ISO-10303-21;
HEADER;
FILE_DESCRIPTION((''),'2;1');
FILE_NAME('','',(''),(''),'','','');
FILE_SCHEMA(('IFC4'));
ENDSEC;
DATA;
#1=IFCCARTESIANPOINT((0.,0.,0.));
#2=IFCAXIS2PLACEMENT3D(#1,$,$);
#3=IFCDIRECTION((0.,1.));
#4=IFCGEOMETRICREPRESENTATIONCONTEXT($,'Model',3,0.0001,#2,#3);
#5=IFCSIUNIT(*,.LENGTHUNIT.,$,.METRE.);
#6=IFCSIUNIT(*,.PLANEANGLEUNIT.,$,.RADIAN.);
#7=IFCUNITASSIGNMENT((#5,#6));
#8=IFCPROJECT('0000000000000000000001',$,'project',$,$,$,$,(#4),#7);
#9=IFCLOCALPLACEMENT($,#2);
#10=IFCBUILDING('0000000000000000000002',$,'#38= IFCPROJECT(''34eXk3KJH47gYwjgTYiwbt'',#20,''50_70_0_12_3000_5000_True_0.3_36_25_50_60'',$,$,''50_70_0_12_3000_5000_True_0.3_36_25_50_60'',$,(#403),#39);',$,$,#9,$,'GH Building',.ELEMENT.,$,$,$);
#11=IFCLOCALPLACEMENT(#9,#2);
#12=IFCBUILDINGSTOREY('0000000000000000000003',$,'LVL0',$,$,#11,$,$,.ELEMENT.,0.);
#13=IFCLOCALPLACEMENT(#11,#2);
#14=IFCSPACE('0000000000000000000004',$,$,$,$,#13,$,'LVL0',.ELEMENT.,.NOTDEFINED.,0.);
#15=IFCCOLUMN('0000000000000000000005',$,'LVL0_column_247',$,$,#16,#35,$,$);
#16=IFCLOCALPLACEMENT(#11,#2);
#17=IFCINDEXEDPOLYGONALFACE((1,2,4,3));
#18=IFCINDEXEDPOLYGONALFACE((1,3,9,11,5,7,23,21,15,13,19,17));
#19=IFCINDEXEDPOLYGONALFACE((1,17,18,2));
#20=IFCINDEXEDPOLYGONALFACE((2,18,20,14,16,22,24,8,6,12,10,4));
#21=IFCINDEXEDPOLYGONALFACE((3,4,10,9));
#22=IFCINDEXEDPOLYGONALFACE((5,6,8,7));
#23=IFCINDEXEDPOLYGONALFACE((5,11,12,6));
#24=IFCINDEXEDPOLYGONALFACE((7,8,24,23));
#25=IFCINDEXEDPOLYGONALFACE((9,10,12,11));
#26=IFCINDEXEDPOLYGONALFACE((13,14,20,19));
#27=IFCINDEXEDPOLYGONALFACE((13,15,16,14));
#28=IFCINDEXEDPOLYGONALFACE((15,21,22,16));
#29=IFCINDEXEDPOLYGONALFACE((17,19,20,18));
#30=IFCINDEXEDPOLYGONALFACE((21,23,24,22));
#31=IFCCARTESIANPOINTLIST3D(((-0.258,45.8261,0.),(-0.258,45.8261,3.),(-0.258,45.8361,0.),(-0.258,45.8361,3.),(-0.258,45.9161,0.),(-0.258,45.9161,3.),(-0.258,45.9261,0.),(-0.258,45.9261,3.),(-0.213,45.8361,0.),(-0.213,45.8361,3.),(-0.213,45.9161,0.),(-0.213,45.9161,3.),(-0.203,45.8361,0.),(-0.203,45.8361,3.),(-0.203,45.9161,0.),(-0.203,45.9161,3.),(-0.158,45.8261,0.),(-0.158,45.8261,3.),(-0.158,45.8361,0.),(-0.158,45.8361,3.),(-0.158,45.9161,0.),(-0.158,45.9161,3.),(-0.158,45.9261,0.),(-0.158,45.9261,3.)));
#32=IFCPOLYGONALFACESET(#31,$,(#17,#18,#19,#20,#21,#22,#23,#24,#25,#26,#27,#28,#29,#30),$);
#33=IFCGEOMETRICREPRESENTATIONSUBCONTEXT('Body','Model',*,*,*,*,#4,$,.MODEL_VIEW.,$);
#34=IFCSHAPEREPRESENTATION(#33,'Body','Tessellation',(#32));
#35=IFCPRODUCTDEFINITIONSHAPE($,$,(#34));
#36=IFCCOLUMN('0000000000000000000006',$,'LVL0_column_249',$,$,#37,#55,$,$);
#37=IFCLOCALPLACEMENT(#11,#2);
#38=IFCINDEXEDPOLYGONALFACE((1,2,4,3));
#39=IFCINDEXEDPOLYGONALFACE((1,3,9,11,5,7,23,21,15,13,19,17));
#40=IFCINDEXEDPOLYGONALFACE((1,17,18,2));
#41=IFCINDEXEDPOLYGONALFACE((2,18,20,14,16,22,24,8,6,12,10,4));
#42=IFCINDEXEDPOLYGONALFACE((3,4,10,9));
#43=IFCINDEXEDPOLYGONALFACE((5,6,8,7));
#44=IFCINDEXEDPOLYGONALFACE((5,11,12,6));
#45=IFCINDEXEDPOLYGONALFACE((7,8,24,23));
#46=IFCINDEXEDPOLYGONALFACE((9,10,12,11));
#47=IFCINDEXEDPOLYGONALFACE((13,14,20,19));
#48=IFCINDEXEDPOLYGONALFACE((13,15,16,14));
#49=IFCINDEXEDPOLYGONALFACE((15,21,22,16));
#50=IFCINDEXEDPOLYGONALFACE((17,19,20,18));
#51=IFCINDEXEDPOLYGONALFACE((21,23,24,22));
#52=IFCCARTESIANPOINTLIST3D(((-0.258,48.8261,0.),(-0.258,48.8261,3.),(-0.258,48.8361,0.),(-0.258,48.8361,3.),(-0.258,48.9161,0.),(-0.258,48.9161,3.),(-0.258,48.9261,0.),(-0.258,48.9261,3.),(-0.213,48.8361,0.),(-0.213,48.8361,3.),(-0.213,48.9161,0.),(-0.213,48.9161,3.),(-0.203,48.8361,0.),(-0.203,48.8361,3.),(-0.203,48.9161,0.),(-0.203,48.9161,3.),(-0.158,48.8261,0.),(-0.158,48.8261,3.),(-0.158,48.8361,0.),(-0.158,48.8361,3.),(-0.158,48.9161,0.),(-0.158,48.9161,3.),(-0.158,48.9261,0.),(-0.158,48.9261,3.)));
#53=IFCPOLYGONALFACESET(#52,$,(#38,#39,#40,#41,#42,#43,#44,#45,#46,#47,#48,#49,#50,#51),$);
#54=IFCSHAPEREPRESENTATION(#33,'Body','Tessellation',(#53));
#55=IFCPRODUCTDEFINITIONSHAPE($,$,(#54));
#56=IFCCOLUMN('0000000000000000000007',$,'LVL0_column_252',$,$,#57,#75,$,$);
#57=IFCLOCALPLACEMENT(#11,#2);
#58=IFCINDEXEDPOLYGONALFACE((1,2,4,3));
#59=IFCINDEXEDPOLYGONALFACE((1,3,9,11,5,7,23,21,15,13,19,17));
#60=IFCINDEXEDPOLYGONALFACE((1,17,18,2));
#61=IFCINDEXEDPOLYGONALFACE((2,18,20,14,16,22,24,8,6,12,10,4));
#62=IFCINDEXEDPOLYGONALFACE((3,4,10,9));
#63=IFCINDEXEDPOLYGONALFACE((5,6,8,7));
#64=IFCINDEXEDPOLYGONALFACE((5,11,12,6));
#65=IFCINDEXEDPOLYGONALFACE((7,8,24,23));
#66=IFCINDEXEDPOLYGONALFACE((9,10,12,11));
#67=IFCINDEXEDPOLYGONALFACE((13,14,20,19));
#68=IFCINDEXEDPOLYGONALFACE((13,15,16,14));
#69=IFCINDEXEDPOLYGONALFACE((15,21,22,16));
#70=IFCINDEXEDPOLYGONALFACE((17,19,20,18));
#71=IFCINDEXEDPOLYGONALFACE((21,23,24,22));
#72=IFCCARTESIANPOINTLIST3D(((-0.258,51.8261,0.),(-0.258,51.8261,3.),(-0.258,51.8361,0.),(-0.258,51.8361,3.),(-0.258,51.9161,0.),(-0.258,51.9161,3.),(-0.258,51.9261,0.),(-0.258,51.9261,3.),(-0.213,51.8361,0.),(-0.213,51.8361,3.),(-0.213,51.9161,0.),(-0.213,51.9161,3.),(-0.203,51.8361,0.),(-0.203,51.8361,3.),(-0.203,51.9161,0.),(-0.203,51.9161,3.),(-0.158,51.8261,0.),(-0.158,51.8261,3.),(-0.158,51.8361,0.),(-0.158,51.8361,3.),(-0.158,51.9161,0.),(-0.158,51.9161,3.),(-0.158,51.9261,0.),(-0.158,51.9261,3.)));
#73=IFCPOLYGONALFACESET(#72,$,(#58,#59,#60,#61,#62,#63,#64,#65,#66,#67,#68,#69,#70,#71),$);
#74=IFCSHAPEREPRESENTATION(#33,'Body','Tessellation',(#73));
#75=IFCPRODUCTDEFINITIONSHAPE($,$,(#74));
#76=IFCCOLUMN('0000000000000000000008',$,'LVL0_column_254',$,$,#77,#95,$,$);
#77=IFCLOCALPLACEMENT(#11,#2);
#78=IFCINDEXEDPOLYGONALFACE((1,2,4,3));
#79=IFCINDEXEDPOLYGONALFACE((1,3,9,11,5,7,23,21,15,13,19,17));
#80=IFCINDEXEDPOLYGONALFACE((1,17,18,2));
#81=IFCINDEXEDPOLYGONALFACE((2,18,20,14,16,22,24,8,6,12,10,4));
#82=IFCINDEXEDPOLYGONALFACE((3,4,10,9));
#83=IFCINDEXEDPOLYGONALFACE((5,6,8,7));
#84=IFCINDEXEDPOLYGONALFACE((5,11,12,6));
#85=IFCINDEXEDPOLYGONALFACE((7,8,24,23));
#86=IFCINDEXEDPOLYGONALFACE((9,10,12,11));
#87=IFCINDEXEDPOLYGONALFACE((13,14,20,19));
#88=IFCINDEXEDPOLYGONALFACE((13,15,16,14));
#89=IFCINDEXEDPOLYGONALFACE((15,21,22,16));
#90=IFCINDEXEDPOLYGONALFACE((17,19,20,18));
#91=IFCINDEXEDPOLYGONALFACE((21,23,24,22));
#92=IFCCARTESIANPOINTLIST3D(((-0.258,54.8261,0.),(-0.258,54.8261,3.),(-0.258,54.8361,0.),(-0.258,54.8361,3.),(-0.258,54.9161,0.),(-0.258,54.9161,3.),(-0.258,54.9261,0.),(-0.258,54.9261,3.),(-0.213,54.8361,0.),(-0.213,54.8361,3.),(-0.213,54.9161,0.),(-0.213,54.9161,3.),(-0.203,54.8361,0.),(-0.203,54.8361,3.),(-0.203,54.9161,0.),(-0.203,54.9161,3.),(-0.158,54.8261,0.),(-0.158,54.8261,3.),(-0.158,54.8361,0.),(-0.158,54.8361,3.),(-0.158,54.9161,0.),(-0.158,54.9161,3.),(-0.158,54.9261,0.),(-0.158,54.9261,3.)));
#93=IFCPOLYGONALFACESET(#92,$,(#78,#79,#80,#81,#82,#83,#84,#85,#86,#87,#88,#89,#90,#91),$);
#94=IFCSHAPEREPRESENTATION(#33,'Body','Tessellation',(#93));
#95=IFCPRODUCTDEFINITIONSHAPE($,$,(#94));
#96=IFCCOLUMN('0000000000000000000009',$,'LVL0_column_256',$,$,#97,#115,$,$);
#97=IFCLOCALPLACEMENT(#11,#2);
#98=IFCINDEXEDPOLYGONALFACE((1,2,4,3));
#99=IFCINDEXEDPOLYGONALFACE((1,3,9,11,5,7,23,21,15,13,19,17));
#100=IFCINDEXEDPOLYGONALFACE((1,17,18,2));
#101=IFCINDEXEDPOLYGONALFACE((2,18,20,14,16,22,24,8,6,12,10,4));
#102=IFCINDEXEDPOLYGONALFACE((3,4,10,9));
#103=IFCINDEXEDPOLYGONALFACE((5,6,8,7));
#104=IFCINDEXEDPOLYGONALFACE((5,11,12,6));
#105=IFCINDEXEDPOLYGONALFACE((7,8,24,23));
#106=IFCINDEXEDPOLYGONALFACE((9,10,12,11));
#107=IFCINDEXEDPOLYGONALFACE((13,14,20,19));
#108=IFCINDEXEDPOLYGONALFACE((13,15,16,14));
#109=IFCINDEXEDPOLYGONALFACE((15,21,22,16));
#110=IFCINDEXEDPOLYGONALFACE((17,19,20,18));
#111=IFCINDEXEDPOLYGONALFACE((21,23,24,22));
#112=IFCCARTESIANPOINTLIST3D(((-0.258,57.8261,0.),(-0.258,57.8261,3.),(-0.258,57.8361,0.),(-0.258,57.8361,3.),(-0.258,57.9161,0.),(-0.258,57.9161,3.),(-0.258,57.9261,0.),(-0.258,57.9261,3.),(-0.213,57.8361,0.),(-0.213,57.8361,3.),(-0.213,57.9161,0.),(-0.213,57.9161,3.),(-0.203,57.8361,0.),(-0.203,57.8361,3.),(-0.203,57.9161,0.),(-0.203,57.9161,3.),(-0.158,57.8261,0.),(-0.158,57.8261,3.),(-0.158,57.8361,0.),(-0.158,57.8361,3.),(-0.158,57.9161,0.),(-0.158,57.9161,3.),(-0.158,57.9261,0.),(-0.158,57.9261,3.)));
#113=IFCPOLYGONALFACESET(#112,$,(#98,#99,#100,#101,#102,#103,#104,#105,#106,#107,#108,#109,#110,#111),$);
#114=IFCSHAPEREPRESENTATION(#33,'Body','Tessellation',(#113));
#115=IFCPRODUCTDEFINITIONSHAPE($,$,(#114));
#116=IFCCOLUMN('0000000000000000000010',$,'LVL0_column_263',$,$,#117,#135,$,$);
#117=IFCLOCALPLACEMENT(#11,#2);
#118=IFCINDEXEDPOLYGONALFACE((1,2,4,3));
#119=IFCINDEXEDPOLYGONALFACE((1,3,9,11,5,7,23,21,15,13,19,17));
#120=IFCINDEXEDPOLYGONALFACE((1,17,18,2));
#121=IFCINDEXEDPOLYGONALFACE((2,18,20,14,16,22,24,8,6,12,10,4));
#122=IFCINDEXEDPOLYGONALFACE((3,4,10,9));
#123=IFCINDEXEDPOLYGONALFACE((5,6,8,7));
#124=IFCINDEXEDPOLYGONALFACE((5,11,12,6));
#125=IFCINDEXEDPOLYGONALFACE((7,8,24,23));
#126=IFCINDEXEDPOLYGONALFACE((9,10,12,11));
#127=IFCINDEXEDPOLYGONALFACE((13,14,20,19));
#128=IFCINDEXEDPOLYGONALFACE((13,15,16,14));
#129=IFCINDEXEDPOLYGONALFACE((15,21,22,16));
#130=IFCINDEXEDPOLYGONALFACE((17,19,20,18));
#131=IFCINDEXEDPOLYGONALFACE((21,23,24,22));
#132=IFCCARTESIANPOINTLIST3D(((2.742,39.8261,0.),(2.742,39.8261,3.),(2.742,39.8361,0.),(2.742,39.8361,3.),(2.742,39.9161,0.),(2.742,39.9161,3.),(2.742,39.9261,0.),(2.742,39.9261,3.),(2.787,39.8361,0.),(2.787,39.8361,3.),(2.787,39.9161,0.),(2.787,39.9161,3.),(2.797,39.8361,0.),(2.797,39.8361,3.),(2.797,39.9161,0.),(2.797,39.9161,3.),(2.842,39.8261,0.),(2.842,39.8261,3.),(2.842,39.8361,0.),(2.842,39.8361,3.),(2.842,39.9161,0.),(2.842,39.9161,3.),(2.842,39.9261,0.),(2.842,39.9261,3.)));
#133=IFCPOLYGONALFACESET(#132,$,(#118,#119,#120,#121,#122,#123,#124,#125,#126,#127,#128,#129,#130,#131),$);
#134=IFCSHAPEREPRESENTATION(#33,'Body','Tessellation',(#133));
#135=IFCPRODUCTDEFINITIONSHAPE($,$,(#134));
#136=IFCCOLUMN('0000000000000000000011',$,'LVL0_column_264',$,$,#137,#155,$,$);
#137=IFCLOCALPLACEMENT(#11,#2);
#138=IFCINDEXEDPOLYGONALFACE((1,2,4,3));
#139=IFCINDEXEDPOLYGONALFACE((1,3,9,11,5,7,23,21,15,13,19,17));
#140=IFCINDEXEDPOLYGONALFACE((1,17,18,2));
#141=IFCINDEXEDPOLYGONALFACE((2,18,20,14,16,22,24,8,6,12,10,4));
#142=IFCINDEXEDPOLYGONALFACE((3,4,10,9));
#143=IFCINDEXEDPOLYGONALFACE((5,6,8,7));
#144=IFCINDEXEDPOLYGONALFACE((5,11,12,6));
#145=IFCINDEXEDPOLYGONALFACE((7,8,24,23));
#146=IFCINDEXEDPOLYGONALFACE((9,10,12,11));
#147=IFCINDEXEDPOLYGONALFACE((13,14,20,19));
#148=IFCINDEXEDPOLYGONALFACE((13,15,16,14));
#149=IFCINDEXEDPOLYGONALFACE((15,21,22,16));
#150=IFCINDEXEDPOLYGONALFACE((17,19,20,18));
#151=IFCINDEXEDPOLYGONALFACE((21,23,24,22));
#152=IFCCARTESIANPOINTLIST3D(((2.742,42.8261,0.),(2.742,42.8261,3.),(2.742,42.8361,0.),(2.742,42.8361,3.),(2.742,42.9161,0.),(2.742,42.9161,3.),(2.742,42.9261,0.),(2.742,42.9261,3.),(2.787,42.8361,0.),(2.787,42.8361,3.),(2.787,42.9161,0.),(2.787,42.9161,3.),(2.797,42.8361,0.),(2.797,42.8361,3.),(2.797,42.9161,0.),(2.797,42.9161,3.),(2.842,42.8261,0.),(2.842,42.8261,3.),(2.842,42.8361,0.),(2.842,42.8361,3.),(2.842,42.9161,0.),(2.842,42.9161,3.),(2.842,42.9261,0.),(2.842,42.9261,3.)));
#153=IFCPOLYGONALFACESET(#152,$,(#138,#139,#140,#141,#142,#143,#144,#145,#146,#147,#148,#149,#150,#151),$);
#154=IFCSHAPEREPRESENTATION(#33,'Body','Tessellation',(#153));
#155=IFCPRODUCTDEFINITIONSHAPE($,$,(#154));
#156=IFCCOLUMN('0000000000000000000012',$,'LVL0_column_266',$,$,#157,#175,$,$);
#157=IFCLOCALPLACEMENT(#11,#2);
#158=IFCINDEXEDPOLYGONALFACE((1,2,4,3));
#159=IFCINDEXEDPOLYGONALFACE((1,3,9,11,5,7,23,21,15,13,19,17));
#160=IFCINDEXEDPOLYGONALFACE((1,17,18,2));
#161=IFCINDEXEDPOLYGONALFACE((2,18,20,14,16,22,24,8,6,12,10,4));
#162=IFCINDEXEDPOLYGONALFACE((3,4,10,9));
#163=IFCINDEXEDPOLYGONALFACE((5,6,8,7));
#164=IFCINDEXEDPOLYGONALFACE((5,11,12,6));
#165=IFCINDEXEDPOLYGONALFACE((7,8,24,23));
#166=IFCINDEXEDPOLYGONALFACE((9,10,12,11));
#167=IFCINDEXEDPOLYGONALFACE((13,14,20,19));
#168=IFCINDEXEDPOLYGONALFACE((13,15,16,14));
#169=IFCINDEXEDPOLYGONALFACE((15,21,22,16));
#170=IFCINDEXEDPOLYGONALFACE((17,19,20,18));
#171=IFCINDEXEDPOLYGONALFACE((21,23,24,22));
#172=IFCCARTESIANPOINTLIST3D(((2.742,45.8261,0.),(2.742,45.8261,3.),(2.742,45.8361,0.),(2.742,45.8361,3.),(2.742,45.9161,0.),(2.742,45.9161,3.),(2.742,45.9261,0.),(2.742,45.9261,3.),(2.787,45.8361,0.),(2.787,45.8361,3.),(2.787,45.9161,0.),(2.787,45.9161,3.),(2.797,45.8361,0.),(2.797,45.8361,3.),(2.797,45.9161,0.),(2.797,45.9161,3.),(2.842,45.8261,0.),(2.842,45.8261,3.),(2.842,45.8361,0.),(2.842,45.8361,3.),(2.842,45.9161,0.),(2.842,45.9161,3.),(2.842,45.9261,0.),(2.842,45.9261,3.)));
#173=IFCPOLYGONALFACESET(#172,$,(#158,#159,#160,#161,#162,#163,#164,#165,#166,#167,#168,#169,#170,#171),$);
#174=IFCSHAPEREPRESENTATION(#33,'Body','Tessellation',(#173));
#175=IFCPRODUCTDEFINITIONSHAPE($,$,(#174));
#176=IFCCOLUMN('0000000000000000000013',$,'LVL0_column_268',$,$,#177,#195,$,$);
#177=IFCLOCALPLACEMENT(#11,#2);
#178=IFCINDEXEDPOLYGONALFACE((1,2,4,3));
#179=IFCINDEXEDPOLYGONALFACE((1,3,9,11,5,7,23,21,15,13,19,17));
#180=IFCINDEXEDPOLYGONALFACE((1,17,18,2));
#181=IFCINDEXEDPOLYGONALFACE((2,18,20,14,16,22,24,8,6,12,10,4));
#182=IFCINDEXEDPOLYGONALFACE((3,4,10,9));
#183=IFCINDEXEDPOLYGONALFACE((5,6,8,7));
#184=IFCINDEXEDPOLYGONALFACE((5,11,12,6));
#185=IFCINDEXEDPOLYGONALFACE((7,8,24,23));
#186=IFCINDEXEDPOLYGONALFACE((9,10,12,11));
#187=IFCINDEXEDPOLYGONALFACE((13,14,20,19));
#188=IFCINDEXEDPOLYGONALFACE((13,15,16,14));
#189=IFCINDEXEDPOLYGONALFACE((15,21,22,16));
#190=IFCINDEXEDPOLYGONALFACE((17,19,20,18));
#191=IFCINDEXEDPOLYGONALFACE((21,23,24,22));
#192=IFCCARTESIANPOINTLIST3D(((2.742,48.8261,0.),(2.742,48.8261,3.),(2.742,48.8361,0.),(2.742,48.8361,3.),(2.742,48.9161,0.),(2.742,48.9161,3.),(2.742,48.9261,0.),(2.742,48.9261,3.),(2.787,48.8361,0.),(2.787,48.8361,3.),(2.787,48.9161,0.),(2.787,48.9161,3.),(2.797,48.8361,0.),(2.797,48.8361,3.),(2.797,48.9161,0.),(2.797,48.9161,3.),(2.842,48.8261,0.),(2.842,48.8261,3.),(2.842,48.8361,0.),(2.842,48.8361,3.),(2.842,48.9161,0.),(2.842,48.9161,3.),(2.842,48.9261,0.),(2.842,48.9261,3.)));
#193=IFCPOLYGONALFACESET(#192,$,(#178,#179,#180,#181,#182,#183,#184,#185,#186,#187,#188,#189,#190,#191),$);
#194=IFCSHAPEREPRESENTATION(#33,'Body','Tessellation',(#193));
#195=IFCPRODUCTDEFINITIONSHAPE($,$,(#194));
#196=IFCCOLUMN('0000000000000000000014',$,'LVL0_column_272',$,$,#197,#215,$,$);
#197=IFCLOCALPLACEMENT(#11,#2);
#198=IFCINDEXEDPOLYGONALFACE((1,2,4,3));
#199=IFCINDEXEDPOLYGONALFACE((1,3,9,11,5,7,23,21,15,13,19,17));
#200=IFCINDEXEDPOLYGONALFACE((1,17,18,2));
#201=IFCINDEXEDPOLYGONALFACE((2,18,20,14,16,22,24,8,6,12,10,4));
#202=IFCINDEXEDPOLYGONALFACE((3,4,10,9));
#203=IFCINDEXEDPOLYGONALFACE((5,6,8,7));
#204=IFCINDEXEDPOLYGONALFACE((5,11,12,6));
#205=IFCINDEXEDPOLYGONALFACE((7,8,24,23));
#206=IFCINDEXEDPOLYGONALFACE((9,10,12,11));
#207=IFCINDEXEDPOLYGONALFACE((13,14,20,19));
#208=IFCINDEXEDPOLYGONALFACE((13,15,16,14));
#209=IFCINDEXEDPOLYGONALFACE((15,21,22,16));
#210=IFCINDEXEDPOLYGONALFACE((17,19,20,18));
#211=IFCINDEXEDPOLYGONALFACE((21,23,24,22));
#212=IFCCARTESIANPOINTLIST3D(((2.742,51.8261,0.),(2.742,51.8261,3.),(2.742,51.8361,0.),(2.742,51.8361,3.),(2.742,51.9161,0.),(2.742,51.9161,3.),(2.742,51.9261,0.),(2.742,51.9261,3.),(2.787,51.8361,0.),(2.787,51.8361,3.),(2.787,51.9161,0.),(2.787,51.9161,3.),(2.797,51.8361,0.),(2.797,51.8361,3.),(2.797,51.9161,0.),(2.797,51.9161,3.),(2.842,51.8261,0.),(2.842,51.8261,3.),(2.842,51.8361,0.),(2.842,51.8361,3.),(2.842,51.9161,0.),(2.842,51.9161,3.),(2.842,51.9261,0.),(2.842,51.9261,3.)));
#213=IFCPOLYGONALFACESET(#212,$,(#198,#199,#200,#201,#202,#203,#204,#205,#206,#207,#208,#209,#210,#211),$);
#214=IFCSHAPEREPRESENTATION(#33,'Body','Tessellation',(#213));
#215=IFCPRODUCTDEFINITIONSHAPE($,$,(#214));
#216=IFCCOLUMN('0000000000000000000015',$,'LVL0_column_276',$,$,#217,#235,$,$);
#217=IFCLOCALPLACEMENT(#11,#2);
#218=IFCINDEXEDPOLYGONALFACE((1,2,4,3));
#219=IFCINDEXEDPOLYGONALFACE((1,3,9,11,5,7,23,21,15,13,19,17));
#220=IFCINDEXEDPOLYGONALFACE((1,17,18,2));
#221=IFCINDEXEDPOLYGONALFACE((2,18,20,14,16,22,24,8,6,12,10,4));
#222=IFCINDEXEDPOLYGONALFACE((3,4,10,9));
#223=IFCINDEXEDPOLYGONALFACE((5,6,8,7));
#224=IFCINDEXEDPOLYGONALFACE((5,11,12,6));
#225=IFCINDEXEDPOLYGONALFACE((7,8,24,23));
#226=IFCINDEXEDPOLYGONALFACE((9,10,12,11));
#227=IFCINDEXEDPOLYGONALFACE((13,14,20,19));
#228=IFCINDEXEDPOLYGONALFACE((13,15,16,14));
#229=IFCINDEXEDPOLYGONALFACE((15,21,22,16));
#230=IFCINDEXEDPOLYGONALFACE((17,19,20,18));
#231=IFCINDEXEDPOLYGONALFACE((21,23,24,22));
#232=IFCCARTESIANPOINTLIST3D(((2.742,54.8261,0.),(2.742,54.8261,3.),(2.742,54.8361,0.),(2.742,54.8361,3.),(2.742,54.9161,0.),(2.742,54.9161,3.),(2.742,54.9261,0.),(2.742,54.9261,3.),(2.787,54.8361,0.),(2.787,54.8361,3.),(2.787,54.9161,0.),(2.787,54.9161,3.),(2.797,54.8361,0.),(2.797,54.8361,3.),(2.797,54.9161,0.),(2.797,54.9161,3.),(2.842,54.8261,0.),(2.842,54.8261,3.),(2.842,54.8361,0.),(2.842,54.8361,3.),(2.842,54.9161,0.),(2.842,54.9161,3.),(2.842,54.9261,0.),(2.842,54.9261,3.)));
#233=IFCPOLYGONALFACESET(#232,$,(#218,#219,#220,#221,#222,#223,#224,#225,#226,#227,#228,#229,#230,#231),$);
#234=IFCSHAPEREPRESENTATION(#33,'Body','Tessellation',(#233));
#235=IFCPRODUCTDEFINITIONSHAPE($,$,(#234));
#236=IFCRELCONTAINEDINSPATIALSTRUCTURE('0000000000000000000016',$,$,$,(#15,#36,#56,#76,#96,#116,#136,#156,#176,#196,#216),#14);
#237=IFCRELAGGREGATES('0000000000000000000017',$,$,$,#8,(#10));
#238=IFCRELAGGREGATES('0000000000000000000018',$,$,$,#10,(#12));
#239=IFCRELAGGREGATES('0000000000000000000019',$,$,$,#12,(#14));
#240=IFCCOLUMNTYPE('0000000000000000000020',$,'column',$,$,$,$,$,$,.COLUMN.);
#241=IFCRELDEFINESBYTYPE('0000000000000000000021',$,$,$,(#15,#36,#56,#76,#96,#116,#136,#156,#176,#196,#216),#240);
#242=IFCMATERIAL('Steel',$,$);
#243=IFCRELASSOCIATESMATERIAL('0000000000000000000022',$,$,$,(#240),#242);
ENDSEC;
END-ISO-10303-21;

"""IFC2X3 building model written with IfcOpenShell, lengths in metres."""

from ifc_helpers import new_model, si_unit, direction, frame, origin, origin_2d, place, context, subcontext, project, spatial, i_section, extrude, material, type_object, element, save


model = new_model("IFC2X3")

# Units and contexts
model_context = context("Model", 3, precision=0.0001, world=origin(), true_north=direction((0.0, 1.0)))
body_context = subcontext(model_context, "Body", "Model", "MODEL_VIEW")
ifc_project = project(units=[si_unit("LENGTHUNIT", "METRE"), si_unit("PLANEANGLEUNIT", "RADIAN")], contexts=[model_context])

# Building, storey, space
building_placement = place(None, origin())
building = spatial("IfcBuilding", under=ifc_project, at=building_placement, Name="#38= IFCPROJECT('34eXk3KJH47gYwjgTYiwbt',#20,'50_70_0_12_3000_5000_True_0.3_36_25_50_60',$,$,'50_70_0_12_3000_5000_True_0.3_36_25_50_60',$,(#403),#39);", LongName="GH Building", CompositionType="ELEMENT")
storey_placement = place(building_placement, origin())
storey = spatial("IfcBuildingStorey", under=building, at=storey_placement, Name="LVL0", CompositionType="ELEMENT", Elevation=0.0)
space_placement = place(storey_placement, origin())
space = spatial("IfcSpace", under=storey, at=space_placement, LongName="LVL0", CompositionType="ELEMENT", InteriorOrExteriorSpace="NOTDEFINED", ElevationWithFlooring=0.0)

# Columns
ifc_material_1 = material(Name="Steel")
column_type = type_object("IfcColumnType", Name="column", PredefinedType="COLUMN", material=ifc_material_1)
for number, where, name in (
    (1, (-0.208, 45.8761, 0.0), "LVL0_column_247"),
    (2, (-0.208, 48.8761, 0.0), "LVL0_column_249"),
    (3, (-0.208, 51.8761, 0.0), "LVL0_column_252"),
    (4, (-0.208, 54.8761, 0.0), "LVL0_column_254"),
    (5, (-0.208, 57.8761, 0.0), "LVL0_column_256"),
    (6, (2.792, 39.8761, 0.0), "LVL0_column_263"),
    (7, (2.792, 42.8761, 0.0), "LVL0_column_264"),
    (8, (2.792, 45.8761, 0.0), "LVL0_column_266"),
    (9, (2.792, 48.8761, 0.0), "LVL0_column_268"),
    (10, (2.792, 51.8761, 0.0), "LVL0_column_272"),
    (11, (2.792, 54.8761, 0.0), "LVL0_column_276"),
):
    element("IfcColumn", number, at=place(space_placement, frame(where)), inside=space, type_object=column_type, Name=name, context=body_context, shape_type="SweptSolid", body=[
        extrude(i_section(OverallWidth=0.1, OverallDepth=0.1, WebThickness=0.01, FlangeThickness=0.01, at=origin_2d()), origin(), (0.0, 0.0, 1.0), 3.0),
    ])

save(model, "model.ifc")
